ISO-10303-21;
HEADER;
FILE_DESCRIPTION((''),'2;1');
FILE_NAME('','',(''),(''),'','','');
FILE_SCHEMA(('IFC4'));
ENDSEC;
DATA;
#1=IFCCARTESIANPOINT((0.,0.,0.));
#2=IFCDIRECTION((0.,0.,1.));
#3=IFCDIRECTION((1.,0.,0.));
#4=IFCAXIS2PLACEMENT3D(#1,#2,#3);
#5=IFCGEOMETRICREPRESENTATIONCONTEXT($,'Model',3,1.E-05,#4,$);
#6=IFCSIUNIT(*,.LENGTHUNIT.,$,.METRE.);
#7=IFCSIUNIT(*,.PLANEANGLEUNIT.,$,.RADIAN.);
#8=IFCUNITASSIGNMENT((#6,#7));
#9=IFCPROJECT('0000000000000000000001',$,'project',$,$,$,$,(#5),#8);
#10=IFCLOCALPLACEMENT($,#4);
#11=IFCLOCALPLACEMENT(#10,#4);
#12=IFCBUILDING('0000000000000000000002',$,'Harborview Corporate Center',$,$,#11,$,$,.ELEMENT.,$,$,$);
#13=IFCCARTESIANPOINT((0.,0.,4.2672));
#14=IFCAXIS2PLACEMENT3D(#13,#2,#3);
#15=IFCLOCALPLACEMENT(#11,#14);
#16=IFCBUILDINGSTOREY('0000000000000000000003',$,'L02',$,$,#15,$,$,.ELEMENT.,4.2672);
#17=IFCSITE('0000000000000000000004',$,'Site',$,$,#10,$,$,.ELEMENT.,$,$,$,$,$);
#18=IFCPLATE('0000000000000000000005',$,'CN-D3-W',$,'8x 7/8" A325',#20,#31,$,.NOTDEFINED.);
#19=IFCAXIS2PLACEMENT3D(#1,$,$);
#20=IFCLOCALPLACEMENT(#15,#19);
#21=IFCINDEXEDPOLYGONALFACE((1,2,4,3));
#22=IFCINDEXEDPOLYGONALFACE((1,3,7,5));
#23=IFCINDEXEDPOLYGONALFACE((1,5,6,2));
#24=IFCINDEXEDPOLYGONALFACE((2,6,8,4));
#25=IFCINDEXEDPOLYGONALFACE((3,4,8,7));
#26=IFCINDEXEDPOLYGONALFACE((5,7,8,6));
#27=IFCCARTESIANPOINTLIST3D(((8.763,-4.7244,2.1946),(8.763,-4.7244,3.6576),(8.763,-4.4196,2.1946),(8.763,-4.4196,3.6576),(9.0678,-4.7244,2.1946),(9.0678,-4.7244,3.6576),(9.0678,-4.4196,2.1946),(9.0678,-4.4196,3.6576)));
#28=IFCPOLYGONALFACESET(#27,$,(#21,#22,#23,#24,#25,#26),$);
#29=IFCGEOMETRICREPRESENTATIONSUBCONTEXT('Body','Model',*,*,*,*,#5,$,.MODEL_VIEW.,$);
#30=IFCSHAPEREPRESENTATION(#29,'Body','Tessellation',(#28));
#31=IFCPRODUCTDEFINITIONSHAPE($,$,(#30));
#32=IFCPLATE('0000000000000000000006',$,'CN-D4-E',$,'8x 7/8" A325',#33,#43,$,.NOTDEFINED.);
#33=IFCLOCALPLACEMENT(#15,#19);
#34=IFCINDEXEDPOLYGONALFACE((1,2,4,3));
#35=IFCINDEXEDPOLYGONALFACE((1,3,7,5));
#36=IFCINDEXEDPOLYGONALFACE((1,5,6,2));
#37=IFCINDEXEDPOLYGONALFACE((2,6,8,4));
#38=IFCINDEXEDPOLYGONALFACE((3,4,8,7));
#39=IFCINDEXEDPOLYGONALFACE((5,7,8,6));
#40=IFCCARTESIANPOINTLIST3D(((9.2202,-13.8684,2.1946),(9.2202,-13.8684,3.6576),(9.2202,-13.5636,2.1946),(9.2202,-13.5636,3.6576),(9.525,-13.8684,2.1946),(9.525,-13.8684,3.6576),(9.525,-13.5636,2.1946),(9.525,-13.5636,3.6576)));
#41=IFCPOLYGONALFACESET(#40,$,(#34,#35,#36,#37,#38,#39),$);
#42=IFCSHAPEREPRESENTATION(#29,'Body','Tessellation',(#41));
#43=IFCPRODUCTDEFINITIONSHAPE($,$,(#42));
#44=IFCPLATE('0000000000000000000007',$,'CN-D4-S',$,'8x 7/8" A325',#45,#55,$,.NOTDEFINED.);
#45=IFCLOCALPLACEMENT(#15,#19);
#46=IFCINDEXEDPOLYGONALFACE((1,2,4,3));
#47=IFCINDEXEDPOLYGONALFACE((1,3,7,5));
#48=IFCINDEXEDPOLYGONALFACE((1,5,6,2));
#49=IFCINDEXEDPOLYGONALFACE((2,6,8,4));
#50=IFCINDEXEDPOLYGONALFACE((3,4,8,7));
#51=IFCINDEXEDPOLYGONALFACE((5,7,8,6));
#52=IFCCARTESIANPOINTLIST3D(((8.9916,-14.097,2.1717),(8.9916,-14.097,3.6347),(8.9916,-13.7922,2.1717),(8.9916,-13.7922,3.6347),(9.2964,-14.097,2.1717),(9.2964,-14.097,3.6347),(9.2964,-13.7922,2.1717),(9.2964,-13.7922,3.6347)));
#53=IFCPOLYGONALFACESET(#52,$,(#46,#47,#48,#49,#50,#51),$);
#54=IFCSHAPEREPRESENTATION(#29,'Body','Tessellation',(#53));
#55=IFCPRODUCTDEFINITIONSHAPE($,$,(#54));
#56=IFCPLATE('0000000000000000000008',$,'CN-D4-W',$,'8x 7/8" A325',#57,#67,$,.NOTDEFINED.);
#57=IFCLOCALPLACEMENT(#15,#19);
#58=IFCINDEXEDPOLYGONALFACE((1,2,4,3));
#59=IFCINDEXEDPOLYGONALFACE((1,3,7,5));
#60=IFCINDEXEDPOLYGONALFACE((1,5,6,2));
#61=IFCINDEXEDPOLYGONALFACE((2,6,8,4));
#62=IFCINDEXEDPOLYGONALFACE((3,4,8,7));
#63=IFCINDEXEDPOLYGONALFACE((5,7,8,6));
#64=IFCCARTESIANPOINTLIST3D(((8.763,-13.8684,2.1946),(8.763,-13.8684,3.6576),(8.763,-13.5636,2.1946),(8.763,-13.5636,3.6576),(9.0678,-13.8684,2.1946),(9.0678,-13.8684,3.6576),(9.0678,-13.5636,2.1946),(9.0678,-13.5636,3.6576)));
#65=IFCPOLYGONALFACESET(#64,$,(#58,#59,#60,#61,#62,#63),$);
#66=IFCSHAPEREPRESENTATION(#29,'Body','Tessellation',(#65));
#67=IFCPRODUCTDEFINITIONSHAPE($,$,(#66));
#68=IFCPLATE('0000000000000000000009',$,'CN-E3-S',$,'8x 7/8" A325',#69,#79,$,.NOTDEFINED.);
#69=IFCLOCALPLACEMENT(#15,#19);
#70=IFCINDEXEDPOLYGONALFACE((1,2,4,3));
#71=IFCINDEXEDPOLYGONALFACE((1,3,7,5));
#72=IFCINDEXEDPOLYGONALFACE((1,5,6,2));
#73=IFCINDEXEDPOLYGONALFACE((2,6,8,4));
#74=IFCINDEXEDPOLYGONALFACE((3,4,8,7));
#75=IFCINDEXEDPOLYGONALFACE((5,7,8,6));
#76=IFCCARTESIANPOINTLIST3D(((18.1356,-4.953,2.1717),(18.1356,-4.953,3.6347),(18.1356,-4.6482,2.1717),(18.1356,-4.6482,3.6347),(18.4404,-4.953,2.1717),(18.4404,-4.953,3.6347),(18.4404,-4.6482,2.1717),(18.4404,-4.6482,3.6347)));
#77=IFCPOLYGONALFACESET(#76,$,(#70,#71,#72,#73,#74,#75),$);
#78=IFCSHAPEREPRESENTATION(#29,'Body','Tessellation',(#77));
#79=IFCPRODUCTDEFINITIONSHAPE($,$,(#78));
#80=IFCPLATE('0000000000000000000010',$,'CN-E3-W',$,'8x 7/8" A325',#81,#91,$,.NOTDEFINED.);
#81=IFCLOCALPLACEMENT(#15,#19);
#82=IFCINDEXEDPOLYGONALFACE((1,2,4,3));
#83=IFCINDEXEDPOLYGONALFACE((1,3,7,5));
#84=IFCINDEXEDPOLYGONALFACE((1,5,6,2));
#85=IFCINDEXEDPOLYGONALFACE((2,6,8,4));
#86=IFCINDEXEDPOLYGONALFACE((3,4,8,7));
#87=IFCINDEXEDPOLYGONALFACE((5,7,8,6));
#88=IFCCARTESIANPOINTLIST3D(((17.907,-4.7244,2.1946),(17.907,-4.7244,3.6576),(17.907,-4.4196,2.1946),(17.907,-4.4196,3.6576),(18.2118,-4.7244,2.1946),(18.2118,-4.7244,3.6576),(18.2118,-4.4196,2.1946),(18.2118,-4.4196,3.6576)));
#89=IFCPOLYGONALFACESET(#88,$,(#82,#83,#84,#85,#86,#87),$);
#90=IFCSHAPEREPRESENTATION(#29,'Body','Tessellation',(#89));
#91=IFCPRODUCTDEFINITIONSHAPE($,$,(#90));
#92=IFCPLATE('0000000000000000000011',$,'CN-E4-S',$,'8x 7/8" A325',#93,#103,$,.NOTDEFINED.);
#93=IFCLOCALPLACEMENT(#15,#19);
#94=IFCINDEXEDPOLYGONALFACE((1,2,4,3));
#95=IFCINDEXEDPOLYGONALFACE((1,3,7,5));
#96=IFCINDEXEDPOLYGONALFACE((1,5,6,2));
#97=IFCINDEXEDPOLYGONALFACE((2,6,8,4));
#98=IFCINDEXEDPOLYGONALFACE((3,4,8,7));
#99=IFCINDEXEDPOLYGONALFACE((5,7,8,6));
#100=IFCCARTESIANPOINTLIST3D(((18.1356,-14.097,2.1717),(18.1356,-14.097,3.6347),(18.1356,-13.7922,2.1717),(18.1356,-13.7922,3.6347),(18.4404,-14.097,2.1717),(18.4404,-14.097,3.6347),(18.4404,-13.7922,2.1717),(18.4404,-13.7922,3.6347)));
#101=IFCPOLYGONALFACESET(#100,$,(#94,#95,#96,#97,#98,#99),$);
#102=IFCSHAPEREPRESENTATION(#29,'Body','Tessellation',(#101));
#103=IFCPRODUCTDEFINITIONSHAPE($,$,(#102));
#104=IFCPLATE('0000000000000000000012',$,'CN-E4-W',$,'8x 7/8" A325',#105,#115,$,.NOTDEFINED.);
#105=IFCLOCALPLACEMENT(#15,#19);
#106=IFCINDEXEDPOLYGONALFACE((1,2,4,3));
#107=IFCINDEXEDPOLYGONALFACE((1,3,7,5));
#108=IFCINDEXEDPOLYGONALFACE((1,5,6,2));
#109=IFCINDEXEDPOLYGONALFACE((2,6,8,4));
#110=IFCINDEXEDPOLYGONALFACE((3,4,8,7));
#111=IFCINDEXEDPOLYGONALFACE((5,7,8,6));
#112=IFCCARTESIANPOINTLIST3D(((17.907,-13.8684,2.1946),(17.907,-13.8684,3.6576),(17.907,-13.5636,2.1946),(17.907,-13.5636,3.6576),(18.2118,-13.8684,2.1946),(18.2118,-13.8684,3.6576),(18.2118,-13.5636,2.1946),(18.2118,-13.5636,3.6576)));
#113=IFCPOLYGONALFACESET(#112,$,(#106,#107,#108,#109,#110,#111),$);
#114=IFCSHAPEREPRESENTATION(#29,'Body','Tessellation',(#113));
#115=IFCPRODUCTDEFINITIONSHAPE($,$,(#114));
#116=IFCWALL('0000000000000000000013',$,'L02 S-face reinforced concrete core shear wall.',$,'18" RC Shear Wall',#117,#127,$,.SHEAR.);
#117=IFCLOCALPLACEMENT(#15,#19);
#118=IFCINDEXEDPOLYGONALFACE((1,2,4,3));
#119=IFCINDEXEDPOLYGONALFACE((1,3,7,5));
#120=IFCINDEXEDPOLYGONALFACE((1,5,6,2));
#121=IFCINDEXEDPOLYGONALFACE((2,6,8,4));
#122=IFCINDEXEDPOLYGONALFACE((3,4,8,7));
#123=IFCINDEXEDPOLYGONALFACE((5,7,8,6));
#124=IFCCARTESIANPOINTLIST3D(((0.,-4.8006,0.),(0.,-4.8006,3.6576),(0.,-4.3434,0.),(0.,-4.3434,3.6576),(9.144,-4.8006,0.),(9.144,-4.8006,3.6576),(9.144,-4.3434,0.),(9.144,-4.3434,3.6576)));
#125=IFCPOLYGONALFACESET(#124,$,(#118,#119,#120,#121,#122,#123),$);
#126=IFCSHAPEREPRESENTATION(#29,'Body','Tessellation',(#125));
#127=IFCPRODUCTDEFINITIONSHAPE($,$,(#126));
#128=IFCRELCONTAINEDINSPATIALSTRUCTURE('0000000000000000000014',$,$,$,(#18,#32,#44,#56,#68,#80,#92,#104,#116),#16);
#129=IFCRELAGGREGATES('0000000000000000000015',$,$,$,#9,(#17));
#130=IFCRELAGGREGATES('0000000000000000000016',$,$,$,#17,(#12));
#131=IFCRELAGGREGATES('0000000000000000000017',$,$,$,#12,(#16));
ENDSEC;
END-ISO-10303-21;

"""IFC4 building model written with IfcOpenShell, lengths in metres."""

from ifc_helpers import new_model, si_unit, frame, origin_with_axes, place, context, subcontext, project, spatial, rectangle, extrude, element, save


model = new_model("IFC4")

# Units and contexts
model_context = context("Model", 3, precision=1e-05, world=origin_with_axes())
body_context = subcontext(model_context, "Body", "Model", "MODEL_VIEW")
ifc_project = project(units=[si_unit("LENGTHUNIT", "METRE"), si_unit("PLANEANGLEUNIT", "RADIAN")], contexts=[model_context])

# Site, building, storey
site_placement = place(None, origin_with_axes())
site = spatial("IfcSite", under=ifc_project, at=site_placement, Name="Site", CompositionType="ELEMENT")
building_placement = place(site_placement, origin_with_axes())
building = spatial("IfcBuilding", under=site, at=building_placement, Name="Harborview Corporate Center", CompositionType="ELEMENT")
storey_placement = place(building_placement, frame((0.0, 0.0, 4.2672), z_axis=(0.0, 0.0, 1.0), x_axis=(1.0, 0.0, 0.0)))
storey = spatial("IfcBuildingStorey", under=building, at=storey_placement, Name="L02", CompositionType="ELEMENT", Elevation=4.2672)

# Plates
for number, where, z_axis, x_axis, name in (
    (1, (8.9154, -4.572, 2.1946), (0.0, 0.0, 1.0), (1.0, 0.0, 0.0), "CN-D3-W"),
    (2, (9.3726, -13.716, 2.1946), (0.0, 0.0, 1.0), (1.0, 0.0, 0.0), "CN-D4-E"),
    (3, (9.144, -13.9446, 2.1717), (0.0, 0.0, 1.0), (1.0, 0.0, 0.0), "CN-D4-S"),
    (4, (8.9154, -13.716, 2.1946), (0.0, 0.0, 1.0), (1.0, 0.0, 0.0), "CN-D4-W"),
    (5, (18.288, -4.8006, 2.1717), (0.0, 0.0, 1.0), (1.0, 0.0, 0.0), "CN-E3-S"),
    (6, (18.0594, -4.572, 2.1946), (0.0, 0.0, 1.0), (1.0, 0.0, 0.0), "CN-E3-W"),
    (7, (18.288, -13.9446, 2.1717), (0.0, 0.0, 1.0), (1.0, 0.0, 0.0), "CN-E4-S"),
    (8, (18.0594, -13.716, 2.1946), (0.0, 0.0, 1.0), (1.0, 0.0, 0.0), "CN-E4-W"),
):
    element("IfcPlate", number, at=place(storey_placement, frame(where, z_axis=z_axis, x_axis=x_axis)), inside=storey, Name=name, ObjectType="8x 7/8\" A325", PredefinedType="NOTDEFINED", context=body_context, shape_type="SweptSolid", body=[
        extrude(rectangle(XDim=0.3048, YDim=0.3048), origin_with_axes(), (0.0, 0.0, 1.0), 1.463),
    ])

# Wall
wall_placement = place(storey_placement, frame((4.572, -4.572, 0.0), z_axis=(0.0, 0.0, 1.0), x_axis=(1.0, 0.0, 0.0)))
element("IfcWall", 9, at=wall_placement, inside=storey, Name="L02 S-face reinforced concrete core shear wall.", ObjectType="18\" RC Shear Wall", PredefinedType="SHEAR", context=body_context, shape_type="SweptSolid", body=[
    extrude(rectangle(XDim=9.144, YDim=0.4572), origin_with_axes(), (0.0, 0.0, 1.0), 3.6576),
])

save(model, "model.ifc")
